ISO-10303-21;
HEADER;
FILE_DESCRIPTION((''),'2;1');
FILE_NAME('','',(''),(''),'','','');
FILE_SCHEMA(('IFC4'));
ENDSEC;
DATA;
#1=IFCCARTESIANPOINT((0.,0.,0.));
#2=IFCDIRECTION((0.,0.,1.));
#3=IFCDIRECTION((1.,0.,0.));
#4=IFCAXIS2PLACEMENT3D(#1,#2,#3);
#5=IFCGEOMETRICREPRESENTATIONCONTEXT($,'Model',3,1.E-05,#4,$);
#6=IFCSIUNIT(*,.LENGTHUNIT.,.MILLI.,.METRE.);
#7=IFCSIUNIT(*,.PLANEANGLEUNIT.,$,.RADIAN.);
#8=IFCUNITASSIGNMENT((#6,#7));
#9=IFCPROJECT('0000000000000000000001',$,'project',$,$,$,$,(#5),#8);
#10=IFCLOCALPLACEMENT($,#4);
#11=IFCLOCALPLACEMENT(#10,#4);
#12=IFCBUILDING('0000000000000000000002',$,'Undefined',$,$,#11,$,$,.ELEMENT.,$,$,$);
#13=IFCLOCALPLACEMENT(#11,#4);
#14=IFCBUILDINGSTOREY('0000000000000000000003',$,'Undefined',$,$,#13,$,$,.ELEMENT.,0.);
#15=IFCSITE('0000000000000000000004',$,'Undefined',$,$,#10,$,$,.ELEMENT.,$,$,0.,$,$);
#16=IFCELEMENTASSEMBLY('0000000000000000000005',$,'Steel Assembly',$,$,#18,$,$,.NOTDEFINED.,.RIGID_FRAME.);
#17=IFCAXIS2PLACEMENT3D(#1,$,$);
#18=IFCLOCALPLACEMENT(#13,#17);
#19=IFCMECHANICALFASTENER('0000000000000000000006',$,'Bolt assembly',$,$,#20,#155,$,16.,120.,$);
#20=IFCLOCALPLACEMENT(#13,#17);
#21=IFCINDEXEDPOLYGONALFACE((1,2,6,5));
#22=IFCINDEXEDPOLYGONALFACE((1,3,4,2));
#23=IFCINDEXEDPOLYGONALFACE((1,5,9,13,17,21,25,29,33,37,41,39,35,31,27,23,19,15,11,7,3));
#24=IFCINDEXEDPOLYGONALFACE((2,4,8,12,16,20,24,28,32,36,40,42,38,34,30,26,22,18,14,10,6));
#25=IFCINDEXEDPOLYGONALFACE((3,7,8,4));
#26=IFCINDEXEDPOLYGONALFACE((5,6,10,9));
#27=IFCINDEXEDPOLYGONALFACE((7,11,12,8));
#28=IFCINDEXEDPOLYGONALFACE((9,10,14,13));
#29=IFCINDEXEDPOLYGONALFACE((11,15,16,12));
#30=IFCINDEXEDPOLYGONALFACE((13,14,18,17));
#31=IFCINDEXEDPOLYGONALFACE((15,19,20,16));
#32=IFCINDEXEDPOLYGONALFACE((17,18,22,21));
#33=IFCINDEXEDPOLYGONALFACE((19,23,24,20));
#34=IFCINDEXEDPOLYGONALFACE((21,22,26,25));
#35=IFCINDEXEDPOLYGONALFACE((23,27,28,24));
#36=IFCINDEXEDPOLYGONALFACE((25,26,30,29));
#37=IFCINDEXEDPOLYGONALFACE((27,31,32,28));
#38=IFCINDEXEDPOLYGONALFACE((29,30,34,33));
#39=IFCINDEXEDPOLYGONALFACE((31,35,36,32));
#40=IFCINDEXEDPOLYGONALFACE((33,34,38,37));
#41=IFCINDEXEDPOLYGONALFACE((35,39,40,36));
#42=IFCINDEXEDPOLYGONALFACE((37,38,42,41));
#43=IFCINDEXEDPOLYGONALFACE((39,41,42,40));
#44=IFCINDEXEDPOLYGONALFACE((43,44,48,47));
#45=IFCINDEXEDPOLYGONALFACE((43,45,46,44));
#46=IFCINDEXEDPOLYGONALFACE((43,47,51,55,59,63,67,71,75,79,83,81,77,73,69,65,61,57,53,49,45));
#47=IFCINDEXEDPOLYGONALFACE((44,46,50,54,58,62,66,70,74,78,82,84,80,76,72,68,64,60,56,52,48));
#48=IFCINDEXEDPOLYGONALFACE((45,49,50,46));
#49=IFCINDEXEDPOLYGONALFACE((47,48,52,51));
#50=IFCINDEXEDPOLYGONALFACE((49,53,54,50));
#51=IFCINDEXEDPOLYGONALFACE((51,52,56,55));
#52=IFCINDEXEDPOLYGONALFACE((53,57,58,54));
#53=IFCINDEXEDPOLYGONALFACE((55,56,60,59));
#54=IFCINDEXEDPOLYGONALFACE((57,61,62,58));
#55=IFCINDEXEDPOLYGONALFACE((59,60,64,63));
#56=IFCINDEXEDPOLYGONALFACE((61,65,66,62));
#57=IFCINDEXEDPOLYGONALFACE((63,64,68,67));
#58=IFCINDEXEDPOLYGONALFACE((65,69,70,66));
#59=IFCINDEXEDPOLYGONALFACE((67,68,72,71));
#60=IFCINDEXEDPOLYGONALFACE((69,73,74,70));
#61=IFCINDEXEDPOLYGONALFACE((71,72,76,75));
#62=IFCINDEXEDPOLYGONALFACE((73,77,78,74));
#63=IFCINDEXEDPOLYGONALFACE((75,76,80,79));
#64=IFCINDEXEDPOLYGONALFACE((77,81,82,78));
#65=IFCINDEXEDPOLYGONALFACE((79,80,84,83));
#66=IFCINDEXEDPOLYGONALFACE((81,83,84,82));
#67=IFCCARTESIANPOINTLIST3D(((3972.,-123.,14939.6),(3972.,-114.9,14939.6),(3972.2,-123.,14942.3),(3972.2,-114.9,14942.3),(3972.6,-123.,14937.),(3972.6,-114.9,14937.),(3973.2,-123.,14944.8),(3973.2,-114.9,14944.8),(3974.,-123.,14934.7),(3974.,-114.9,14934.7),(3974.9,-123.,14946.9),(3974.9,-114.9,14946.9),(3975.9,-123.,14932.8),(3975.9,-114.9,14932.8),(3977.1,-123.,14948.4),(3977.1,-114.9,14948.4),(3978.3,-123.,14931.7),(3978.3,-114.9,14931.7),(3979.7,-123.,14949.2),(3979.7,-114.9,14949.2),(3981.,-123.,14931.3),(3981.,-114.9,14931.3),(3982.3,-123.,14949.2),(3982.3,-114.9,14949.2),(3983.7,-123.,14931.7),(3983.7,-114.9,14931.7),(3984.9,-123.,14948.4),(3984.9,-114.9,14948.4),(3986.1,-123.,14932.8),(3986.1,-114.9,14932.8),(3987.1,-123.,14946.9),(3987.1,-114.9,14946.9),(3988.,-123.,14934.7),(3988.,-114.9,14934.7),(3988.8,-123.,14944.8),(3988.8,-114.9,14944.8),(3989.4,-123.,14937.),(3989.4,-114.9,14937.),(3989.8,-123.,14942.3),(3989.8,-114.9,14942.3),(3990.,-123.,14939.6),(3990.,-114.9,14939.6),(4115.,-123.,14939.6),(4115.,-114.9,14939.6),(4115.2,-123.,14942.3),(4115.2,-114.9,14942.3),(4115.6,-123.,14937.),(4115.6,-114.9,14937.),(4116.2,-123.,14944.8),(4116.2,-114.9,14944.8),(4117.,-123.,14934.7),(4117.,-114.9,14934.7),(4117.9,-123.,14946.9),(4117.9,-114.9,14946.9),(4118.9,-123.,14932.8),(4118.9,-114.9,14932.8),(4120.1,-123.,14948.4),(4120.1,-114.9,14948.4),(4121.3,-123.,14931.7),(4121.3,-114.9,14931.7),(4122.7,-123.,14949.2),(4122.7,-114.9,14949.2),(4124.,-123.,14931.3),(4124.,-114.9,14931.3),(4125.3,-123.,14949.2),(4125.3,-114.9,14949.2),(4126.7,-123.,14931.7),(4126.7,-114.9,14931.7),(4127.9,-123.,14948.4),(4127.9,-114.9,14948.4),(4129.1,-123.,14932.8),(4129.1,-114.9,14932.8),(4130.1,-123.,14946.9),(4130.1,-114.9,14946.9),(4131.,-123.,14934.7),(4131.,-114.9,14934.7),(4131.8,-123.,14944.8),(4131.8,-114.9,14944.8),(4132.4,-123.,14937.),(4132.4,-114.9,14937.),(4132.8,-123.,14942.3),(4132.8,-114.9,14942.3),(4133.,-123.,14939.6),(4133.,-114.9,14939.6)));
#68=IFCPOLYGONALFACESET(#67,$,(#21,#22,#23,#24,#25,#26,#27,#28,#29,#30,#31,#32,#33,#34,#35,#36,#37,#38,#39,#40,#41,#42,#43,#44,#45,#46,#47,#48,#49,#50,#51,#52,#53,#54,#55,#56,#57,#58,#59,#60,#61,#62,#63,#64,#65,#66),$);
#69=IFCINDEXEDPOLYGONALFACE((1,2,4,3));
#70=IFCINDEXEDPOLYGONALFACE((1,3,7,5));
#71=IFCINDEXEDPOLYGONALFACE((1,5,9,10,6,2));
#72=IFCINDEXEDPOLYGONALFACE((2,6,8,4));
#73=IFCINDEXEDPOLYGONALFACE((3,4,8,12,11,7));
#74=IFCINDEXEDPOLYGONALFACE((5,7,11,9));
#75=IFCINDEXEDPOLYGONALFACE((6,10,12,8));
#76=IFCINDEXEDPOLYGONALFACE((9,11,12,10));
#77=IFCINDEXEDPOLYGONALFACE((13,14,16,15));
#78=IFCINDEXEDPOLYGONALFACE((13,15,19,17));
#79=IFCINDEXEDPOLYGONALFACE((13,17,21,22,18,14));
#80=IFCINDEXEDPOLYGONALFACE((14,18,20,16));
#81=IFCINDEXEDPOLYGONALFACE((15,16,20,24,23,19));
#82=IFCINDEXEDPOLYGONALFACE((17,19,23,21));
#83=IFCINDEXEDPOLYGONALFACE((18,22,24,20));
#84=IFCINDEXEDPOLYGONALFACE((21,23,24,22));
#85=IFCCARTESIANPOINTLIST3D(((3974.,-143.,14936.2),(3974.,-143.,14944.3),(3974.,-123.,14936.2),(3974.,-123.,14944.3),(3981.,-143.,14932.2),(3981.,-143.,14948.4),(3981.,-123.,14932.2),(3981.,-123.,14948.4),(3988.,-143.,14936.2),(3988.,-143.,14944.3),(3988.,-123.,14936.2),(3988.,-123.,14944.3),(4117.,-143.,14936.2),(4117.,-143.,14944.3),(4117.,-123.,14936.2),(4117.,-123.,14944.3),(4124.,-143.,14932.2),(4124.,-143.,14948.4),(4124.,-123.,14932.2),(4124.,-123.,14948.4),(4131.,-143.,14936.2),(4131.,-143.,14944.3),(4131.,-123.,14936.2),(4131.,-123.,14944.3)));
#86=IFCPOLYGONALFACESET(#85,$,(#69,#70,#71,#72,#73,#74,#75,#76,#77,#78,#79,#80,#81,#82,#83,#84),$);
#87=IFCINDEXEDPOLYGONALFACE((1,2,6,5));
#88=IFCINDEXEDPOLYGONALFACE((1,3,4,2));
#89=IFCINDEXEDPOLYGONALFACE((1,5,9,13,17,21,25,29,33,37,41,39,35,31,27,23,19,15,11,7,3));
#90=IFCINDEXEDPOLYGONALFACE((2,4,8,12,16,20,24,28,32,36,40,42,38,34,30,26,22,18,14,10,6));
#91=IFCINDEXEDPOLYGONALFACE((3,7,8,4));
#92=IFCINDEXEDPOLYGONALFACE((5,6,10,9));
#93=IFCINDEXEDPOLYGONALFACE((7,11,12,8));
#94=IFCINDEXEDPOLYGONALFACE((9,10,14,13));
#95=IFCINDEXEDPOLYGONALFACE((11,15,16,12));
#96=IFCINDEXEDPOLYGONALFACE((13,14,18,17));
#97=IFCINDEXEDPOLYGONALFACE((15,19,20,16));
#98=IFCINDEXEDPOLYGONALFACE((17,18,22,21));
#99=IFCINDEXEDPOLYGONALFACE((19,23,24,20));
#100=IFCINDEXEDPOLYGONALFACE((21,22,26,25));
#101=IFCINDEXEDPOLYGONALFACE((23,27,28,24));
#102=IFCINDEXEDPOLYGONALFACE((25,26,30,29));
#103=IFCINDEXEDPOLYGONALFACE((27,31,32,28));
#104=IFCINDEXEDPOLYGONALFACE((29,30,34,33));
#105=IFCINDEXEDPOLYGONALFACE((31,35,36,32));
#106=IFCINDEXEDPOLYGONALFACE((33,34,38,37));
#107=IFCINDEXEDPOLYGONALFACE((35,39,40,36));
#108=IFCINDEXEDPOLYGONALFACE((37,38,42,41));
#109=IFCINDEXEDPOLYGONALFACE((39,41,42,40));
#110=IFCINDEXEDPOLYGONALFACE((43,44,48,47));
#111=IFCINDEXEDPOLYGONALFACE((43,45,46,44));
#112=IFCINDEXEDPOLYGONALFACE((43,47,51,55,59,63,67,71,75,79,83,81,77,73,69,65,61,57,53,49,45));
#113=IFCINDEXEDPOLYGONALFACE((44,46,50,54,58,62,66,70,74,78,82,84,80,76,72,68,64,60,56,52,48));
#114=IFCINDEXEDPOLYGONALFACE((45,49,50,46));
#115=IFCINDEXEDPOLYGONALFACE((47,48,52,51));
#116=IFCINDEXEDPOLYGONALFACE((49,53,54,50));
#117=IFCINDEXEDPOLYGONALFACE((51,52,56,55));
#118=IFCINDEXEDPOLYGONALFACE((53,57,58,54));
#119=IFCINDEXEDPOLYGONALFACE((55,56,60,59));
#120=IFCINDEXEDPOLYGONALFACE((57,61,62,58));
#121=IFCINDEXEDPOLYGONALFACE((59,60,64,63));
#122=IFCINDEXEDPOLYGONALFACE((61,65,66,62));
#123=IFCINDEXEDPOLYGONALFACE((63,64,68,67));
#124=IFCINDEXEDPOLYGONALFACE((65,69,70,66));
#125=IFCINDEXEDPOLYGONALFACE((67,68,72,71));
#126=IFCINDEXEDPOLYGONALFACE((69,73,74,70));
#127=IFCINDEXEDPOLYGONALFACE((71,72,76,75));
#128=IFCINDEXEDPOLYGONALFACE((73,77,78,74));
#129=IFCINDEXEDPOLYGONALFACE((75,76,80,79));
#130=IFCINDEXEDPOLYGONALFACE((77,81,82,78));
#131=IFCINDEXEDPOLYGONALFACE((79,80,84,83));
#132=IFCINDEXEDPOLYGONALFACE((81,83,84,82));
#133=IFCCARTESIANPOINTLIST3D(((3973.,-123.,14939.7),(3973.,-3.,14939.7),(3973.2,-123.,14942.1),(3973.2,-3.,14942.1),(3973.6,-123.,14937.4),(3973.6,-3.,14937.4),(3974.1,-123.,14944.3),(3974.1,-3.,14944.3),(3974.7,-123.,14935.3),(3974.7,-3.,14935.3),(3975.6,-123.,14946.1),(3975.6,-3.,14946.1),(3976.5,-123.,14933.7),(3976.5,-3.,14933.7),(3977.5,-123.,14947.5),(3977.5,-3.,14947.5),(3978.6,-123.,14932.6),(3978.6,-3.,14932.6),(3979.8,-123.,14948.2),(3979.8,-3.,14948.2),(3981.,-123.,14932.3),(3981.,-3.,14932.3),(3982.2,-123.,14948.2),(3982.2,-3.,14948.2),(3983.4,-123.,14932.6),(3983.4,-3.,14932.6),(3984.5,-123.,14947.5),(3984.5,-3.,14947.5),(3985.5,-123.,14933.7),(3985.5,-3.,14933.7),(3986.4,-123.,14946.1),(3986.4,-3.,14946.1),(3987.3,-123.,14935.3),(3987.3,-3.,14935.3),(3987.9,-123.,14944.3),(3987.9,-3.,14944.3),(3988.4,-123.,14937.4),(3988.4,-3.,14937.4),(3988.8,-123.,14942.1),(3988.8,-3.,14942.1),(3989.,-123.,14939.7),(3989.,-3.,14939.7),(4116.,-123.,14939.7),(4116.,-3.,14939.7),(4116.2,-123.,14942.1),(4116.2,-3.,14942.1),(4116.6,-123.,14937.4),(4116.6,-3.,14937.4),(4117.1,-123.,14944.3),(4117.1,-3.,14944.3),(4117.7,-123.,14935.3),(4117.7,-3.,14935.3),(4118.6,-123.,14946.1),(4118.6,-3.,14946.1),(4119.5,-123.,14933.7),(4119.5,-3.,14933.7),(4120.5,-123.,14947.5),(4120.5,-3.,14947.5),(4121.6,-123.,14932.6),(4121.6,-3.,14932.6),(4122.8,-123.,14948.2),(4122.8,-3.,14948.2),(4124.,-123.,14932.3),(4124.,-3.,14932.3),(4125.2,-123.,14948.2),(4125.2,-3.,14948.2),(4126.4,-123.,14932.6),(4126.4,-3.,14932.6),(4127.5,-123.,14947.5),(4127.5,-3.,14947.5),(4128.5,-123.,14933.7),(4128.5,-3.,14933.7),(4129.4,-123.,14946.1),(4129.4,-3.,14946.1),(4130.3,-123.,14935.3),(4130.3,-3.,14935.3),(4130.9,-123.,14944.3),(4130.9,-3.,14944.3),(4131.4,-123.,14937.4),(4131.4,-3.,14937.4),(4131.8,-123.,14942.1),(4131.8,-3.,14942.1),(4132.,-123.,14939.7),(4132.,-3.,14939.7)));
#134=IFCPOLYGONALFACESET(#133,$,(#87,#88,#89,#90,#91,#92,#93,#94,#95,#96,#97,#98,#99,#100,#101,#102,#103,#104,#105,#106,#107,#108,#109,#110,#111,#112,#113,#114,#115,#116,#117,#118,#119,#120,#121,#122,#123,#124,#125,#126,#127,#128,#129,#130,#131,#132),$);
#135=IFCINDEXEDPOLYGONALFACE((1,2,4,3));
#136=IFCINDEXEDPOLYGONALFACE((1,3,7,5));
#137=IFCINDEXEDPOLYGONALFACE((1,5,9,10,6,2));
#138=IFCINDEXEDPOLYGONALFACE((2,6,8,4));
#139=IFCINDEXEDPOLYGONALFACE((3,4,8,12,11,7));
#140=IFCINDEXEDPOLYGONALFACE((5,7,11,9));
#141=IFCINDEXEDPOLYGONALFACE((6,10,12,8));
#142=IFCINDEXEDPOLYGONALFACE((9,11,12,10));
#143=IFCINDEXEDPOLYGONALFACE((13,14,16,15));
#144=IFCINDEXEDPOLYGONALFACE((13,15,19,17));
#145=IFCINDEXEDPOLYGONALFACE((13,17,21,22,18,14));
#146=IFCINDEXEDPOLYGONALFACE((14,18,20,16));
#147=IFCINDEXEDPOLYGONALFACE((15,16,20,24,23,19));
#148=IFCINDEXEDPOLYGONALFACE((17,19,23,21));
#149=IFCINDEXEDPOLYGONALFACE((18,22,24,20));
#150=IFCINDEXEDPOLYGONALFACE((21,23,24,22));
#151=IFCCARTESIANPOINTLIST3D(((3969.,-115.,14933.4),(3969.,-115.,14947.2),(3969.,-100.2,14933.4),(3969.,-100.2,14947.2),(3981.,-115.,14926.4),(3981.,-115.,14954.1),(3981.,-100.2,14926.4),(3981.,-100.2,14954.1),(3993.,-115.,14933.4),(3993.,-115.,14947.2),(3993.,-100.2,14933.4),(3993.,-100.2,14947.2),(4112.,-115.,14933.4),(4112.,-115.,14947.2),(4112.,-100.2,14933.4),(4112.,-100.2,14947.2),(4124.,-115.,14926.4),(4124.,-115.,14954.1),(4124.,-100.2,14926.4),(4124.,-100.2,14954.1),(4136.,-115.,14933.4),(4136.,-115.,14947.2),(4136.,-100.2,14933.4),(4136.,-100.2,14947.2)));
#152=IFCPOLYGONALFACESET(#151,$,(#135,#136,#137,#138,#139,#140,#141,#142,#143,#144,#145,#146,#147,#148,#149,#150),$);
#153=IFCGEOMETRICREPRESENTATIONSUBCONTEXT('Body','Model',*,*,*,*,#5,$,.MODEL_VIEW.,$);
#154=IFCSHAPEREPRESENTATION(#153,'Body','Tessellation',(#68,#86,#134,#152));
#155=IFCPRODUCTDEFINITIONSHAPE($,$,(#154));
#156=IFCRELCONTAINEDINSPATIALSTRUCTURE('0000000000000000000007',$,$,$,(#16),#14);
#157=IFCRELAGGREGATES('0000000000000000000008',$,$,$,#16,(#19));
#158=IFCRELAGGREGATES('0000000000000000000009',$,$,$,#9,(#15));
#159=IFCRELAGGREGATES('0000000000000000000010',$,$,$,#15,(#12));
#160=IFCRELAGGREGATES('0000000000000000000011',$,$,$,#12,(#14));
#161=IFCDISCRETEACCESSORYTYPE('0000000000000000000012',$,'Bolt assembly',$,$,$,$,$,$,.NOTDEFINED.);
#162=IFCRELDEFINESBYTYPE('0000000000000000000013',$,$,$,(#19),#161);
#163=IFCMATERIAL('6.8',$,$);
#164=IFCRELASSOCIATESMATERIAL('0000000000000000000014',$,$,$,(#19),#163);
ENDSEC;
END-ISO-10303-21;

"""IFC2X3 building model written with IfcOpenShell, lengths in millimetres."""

from ifc_helpers import new_model, si_unit, frame, origin_with_axes, origin_2d_with_axis, place, context, subcontext, project, spatial, polyline, circle, outline, extrude, source, transform, mapped, material, type_object, element, aggregate, save


model = new_model("IFC2X3")

# Units and contexts
model_context = context("Model", 3, precision=1e-05, world=origin_with_axes())
body_context = subcontext(model_context, "Body", "Model", "MODEL_VIEW")
ifc_project = project(units=[si_unit("LENGTHUNIT", "METRE", prefix="MILLI"), si_unit("PLANEANGLEUNIT", "RADIAN")], contexts=[model_context])

# Site, building, storey
site_placement = place(None, origin_with_axes())
site = spatial("IfcSite", under=ifc_project, at=site_placement, Name="Undefined", CompositionType="ELEMENT", RefElevation=0.0)
building_placement = place(site_placement, origin_with_axes())
building = spatial("IfcBuilding", under=site, at=building_placement, Name="Undefined", CompositionType="ELEMENT")
storey_placement = place(building_placement, origin_with_axes())
storey = spatial("IfcBuildingStorey", under=building, at=storey_placement, Name="Undefined", CompositionType="ELEMENT", Elevation=0.0)

# Element assembly
assembly_1_placement = place(storey_placement, origin_with_axes())
assembly_1 = element("IfcElementAssembly", 1, at=assembly_1_placement, inside=storey, Name="Steel Assembly", AssemblyPlace="NOTDEFINED", PredefinedType="RIGID_FRAME")

# Shared definitions
discrete_accessory_type_1 = type_object("IfcDiscreteAccessoryType", Name="Bolt assembly")

# Mechanical fastener
ifc_material_1 = material(Name="6.8")
shared_shape_1 = source(origin_with_axes(), body_context, "Body", "SweptSolid", [
    extrude(circle(Radius=9.0, at=origin_2d_with_axis()), frame((0.0, 0.0, 0.0), z_axis=(0.0, 1.0, 0.0), x_axis=(1.0, 0.0, 0.0)), (0.0, 0.0, 1.0), 8.1),
    extrude(outline(polyline([(8.1, 0.0), (4.0, 7.0), (-4.0, 7.0), (-8.1, 0.0), (-4.0, -7.0), (4.0, -7.0), (8.1, 0.0)])), frame((0.0, -20.0, 0.0), z_axis=(0.0, 1.0, 0.0), x_axis=(1.0, 0.0, 0.0)), (0.0, 0.0, 1.0), 20.0),
    extrude(circle(Radius=8.0, at=origin_2d_with_axis()), frame((0.0, 0.0, 0.0), z_axis=(0.0, 1.0, 0.0), x_axis=(1.0, 0.0, 0.0)), (0.0, 0.0, 1.0), 120.0),
    extrude(outline(polyline([(13.9, 0.0), (6.9, 12.0), (-6.9, 12.0), (-13.9, 0.0), (-6.9, -12.0), (6.9, -12.0), (13.9, 0.0)])), frame((0.0, 8.0, 0.0), z_axis=(0.0, 1.0, 0.0), x_axis=(1.0, 0.0, 0.0)), (0.0, 0.0, 1.0), 14.8),
])
mechanical_fastener_1_placement = place(assembly_1_placement, frame((4052.5, -123.0, 14990.8), z_axis=(1.0, 0.0, 0.0), x_axis=(0.0, 0.0, -1.0)))
mechanical_fastener_1 = element("IfcMechanicalFastener", 2, at=mechanical_fastener_1_placement, type_object=discrete_accessory_type_1, material=ifc_material_1, Name="Bolt assembly", NominalDiameter=16.0, NominalLength=120.0, context=body_context, shape_type="MappedRepresentation", body=[
    mapped(shared_shape_1, transform((50.5, 0.0, -71.5))),
    mapped(shared_shape_1, transform((50.5, 0.0, 71.5))),
])
aggregate(assembly_1, [mechanical_fastener_1])

save(model, "model.ifc")
